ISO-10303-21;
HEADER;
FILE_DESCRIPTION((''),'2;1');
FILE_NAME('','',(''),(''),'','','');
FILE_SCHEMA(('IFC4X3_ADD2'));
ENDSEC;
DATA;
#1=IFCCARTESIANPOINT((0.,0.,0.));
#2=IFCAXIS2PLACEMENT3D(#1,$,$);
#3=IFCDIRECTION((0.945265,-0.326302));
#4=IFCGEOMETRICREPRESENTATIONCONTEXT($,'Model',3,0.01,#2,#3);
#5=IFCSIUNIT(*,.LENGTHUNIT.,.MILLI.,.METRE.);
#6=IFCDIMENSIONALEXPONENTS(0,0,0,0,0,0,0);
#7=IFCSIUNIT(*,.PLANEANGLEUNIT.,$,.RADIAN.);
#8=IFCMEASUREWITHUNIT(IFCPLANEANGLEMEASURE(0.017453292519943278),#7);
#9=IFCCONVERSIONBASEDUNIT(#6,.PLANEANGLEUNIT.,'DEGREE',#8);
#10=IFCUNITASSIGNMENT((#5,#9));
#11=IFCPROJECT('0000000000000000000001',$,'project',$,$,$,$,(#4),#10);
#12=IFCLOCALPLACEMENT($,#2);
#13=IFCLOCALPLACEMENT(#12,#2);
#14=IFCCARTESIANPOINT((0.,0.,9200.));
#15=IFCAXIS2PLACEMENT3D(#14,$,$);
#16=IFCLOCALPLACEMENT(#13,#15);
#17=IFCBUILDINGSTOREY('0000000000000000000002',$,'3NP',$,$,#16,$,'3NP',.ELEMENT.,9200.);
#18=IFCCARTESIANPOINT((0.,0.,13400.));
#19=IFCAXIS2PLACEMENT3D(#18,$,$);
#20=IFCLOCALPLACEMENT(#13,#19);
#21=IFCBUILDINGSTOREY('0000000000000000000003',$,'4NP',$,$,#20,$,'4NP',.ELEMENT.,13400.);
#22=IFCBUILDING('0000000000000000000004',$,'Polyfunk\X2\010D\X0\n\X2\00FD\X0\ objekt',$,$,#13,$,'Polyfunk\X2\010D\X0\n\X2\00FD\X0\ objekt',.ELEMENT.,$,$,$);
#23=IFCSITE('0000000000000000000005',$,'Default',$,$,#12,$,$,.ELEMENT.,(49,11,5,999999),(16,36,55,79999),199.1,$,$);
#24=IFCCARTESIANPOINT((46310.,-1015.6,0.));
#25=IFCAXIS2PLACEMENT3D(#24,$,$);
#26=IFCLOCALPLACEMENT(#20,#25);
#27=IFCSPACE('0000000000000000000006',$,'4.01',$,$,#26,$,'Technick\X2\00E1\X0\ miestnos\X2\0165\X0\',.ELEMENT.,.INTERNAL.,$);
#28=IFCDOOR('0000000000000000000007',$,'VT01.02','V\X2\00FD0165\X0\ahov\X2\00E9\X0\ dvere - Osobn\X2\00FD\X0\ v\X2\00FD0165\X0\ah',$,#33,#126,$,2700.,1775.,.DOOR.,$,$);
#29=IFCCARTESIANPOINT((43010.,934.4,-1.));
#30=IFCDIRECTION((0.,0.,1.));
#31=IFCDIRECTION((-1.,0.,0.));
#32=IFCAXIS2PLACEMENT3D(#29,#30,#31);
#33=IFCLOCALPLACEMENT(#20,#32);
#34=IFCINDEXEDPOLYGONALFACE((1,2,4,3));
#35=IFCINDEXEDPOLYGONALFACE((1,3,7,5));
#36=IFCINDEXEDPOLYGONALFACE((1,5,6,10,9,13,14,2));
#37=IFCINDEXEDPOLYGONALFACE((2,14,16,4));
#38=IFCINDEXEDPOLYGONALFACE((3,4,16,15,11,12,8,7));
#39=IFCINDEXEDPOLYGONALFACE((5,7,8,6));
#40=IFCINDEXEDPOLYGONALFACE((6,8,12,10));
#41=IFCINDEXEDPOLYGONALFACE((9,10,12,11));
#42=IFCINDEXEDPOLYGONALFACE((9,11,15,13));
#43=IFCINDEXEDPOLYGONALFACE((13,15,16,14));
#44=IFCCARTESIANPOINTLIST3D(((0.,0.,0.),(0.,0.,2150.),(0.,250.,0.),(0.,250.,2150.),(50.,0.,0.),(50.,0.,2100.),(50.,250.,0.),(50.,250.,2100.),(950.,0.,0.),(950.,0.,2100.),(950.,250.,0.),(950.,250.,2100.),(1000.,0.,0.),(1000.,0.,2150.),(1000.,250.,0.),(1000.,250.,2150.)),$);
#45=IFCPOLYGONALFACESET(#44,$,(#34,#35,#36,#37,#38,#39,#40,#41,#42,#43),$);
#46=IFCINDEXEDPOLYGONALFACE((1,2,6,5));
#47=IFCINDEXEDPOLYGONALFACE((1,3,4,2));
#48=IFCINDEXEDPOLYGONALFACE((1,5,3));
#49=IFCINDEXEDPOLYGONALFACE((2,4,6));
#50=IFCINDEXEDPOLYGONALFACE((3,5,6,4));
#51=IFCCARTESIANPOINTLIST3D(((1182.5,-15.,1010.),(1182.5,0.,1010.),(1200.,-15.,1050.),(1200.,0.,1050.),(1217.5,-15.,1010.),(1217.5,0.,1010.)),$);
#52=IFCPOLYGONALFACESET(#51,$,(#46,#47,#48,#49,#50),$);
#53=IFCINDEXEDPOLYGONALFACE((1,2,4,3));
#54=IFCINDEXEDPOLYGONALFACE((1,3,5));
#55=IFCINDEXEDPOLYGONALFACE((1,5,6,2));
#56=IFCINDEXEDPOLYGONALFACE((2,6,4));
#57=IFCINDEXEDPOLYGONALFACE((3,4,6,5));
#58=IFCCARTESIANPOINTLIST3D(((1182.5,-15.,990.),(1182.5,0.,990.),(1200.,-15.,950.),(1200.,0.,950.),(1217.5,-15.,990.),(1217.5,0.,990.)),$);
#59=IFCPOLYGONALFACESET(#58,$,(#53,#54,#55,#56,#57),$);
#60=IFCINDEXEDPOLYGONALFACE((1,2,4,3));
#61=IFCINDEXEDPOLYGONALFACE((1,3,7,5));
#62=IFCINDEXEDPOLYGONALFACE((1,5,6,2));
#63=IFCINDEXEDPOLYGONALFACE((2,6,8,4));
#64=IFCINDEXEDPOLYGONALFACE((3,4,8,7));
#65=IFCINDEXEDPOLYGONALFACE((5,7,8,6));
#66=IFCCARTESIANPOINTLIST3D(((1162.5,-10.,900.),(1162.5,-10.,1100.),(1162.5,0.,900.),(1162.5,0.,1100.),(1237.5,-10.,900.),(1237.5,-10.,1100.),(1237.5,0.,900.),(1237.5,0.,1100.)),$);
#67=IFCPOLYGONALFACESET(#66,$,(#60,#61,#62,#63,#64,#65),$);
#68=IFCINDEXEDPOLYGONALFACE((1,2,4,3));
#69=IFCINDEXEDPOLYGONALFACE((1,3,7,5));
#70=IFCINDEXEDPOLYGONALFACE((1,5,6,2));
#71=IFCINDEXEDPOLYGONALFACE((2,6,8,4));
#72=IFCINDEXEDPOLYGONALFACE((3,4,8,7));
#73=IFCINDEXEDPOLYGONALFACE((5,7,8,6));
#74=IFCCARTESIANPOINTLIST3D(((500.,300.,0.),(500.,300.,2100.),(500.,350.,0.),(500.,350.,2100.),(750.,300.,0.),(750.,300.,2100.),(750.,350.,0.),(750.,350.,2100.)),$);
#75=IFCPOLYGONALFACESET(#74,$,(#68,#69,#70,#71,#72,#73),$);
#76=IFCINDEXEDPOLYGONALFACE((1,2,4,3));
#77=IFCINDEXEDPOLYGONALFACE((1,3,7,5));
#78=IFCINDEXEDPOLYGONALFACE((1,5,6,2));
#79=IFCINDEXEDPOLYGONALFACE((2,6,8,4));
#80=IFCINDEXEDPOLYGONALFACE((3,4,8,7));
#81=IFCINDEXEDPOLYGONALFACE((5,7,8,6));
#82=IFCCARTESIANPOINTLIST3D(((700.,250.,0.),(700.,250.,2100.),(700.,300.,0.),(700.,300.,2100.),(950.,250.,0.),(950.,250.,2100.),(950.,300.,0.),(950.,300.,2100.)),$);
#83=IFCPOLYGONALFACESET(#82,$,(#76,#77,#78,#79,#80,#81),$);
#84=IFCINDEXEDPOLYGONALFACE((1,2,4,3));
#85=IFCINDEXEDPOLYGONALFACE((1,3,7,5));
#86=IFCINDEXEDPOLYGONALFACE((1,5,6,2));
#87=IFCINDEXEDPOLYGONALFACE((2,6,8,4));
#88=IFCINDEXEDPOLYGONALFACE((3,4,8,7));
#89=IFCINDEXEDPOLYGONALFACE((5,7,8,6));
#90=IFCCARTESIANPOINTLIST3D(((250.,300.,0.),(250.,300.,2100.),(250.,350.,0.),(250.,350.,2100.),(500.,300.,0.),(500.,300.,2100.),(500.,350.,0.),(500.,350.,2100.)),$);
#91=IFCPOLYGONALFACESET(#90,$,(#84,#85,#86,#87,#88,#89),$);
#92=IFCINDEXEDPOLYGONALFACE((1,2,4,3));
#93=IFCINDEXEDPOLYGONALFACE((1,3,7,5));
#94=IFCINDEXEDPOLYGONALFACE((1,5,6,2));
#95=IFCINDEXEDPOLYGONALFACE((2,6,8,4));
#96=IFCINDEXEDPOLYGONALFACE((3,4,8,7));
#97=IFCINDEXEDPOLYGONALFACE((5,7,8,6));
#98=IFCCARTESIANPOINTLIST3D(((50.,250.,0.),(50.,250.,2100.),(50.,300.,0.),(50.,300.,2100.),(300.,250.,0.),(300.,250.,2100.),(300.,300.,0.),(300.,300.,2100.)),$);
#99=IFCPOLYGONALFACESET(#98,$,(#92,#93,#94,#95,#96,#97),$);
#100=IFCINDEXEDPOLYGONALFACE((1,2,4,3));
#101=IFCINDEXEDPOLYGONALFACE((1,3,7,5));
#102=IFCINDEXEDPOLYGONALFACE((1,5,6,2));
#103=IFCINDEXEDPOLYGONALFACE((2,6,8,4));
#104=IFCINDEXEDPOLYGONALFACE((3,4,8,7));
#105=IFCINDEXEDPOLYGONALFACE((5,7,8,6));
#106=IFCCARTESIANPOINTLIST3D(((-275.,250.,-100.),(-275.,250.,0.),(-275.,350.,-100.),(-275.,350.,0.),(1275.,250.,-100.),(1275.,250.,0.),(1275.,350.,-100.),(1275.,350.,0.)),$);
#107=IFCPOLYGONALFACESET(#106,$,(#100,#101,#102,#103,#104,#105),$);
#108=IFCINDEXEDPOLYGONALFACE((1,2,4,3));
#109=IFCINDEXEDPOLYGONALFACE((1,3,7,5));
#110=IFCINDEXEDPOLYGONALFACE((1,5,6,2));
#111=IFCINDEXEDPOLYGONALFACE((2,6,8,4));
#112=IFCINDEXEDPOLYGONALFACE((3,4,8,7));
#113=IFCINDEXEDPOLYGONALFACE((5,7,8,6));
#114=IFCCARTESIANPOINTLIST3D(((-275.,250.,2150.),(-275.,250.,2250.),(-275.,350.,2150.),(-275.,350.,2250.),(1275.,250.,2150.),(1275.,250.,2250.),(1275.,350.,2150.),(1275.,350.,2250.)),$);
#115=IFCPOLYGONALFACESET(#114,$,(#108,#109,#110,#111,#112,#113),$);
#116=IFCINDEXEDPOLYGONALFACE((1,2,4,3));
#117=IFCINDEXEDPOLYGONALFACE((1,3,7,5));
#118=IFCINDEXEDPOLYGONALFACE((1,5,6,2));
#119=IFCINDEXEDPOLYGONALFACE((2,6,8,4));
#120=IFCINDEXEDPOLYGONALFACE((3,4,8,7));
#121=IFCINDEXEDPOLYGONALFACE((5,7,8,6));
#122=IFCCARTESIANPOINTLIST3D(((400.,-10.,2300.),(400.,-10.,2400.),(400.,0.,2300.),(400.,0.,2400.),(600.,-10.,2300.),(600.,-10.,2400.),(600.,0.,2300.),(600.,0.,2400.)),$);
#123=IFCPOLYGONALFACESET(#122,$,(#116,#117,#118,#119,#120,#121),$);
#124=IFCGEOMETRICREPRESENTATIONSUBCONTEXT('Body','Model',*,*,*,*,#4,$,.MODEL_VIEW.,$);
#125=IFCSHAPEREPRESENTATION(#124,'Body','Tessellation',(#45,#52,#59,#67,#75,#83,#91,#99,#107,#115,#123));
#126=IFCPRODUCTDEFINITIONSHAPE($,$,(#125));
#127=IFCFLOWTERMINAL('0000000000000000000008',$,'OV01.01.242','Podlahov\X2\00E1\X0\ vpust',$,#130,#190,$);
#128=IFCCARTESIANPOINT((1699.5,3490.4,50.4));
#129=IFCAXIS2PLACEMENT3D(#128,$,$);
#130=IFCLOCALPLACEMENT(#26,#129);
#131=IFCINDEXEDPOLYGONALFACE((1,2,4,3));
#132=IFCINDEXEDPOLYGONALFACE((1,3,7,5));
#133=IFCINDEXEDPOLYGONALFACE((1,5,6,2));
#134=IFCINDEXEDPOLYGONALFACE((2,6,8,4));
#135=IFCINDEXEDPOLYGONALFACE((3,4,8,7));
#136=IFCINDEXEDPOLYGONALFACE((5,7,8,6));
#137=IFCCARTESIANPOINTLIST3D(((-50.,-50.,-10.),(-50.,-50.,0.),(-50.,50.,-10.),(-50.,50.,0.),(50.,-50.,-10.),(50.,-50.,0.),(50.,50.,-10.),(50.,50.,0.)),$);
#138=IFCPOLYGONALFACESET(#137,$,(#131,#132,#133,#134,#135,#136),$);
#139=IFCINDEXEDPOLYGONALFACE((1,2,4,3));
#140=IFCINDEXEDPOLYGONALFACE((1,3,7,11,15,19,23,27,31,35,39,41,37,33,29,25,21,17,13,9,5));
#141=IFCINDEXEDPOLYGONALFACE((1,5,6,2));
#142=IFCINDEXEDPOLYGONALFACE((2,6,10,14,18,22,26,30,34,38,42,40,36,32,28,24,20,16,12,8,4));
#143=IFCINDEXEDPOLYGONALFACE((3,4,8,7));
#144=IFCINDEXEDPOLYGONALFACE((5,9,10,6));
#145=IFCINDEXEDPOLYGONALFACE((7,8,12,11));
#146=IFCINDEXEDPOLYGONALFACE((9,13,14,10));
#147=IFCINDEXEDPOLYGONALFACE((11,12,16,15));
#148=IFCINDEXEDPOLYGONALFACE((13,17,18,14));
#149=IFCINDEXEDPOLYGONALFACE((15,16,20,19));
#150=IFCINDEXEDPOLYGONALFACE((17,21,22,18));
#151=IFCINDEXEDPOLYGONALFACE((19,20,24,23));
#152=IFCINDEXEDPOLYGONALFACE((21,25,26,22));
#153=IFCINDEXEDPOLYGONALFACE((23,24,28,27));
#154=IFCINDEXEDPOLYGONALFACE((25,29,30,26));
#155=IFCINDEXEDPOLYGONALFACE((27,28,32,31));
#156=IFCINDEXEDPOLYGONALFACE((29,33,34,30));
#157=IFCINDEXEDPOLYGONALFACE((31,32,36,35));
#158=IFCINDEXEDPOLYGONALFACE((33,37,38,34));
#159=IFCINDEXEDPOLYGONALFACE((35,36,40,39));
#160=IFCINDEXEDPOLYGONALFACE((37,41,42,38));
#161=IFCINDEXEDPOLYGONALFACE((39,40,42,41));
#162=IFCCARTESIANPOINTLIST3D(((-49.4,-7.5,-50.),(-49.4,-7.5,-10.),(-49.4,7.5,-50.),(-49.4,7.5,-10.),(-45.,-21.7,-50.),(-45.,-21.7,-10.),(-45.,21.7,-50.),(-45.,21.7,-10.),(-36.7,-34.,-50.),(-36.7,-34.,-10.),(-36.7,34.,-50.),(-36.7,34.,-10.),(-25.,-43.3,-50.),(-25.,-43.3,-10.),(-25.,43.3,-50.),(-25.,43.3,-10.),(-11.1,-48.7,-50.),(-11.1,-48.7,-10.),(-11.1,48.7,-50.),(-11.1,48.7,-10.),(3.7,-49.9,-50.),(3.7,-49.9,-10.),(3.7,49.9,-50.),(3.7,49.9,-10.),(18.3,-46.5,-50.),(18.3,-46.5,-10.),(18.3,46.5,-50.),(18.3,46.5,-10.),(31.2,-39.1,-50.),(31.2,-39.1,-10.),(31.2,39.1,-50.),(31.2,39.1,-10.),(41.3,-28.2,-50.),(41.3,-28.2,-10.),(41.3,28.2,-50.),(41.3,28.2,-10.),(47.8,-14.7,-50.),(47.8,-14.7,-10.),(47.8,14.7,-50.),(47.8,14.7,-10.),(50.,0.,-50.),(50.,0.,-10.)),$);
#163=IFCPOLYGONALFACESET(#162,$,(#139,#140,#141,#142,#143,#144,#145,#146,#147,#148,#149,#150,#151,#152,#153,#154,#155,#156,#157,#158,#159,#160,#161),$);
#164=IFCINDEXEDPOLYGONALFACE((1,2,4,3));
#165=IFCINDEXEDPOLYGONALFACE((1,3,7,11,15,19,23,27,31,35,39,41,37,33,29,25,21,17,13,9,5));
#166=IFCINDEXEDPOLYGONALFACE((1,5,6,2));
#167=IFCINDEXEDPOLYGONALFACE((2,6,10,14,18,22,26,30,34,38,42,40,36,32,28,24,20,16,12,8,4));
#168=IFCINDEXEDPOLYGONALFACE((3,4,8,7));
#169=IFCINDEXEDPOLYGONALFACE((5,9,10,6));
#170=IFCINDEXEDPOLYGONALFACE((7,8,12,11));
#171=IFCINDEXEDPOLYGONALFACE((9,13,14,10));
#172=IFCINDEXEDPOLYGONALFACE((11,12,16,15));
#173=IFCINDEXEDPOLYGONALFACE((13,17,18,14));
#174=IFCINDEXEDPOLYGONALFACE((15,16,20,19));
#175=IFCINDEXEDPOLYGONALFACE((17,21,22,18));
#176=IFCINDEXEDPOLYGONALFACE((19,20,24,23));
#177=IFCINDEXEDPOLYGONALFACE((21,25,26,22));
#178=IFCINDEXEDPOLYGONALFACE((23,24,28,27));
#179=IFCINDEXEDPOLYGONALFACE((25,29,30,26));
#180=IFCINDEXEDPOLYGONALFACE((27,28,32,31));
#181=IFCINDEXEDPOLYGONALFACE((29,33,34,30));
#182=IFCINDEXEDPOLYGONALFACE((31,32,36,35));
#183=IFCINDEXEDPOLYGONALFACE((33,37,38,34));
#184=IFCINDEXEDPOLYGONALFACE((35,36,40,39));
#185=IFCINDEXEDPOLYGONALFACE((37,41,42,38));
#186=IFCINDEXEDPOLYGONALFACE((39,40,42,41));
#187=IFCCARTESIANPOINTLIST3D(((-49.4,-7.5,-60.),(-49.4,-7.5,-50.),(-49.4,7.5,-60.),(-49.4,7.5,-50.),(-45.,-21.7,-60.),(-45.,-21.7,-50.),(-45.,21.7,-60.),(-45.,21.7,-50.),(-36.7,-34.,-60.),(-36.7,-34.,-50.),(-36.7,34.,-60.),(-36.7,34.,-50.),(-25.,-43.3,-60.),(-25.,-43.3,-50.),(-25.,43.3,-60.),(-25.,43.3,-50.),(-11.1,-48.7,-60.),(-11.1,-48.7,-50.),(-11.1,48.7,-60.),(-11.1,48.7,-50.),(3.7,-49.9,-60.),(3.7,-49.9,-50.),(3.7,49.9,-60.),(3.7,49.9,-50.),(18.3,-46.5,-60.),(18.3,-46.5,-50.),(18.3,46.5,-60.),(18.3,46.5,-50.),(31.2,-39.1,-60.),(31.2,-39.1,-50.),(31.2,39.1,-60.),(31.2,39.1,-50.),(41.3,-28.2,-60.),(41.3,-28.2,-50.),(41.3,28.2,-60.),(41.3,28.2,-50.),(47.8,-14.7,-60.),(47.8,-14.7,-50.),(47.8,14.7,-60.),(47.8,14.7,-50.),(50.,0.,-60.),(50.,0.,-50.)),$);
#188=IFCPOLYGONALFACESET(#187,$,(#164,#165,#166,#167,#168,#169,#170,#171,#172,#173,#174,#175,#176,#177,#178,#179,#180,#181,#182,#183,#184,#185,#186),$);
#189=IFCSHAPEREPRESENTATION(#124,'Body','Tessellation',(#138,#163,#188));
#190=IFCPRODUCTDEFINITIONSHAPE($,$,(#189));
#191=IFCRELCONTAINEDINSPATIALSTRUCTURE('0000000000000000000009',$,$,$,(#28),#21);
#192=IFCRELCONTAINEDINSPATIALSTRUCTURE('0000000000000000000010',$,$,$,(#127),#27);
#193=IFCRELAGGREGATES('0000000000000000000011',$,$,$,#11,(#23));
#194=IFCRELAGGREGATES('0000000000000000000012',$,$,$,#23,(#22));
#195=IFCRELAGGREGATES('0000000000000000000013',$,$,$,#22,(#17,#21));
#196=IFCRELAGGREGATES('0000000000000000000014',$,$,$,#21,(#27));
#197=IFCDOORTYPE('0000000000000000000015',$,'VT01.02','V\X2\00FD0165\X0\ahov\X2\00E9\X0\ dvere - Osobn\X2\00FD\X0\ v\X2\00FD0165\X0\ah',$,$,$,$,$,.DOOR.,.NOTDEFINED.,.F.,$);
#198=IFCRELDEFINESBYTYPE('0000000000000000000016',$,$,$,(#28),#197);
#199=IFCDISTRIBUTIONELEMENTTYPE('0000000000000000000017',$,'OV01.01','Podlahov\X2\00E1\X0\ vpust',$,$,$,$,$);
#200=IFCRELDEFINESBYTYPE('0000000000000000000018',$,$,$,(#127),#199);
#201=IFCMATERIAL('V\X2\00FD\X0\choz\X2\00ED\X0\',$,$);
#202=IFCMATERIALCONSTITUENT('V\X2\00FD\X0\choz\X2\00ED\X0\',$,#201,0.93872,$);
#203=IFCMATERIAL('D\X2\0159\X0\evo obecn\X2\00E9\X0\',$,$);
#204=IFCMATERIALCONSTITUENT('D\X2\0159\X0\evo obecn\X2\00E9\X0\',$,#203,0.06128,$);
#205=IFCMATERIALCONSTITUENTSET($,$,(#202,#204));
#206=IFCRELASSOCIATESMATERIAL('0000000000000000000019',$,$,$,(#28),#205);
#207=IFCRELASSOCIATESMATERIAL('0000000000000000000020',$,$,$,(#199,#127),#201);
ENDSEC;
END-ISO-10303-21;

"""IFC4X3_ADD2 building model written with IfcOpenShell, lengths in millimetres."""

from ifc_helpers import new_model, entity, si_unit, converted_unit, direction, frame, frame_2d, origin, origin_2d_with_axis, place, context, subcontext, project, spatial, polyline, rectangle, circle, outline, extrude, source, transform, mapped, material, constituent, constituent_set, type_object, type_shapes, element, save


model = new_model("IFC4X3_ADD2")

# Units and contexts
model_context = context("Model", 3, precision=0.01, world=origin(), true_north=direction((0.945265, -0.326302)))
body_context = subcontext(model_context, "Body", "Model", "MODEL_VIEW")
ifc_project = project(units=[si_unit("LENGTHUNIT", "METRE", prefix="MILLI"), converted_unit("PLANEANGLEUNIT", "DEGREE", entity("IfcPlaneAngleMeasure", 0.017453292519943278), si_unit("PLANEANGLEUNIT", "RADIAN"), dimensions=[0, 0, 0, 0, 0, 0, 0])], contexts=[model_context])

# Site, building, storey
site_placement = place(None, origin())
site = spatial("IfcSite", under=ifc_project, at=site_placement, Name="Default", CompositionType="ELEMENT", RefLatitude=(49, 11, 5, 999999), RefLongitude=(16, 36, 55, 79999), RefElevation=199.1)
building_placement = place(site_placement, origin())
building = spatial("IfcBuilding", under=site, at=building_placement, Name="Polyfunkčný objekt", LongName="Polyfunkčný objekt", CompositionType="ELEMENT")
storey_1_placement = place(building_placement, frame((0.0, 0.0, 9200.0)))
storey_1 = spatial("IfcBuildingStorey", under=building, at=storey_1_placement, Name="3NP", LongName="3NP", CompositionType="ELEMENT", Elevation=9200.0)

# Shared definitions
storey_2_placement = place(building_placement, frame((0.0, 0.0, 13400.0)))
storey_2 = spatial("IfcBuildingStorey", under=building, at=storey_2_placement, Name="4NP", LongName="4NP", CompositionType="ELEMENT", Elevation=13400.0)

# Shared definitions
ifc_material_1 = material(Name="Dřevo obecné")

# Door
ifc_material_2 = material(Name="Výchozí")
ifc_constituent_1 = constituent(ifc_material_2, Name="Výchozí", fraction=0.93872)
ifc_constituent_2 = constituent(ifc_material_1, Name="Dřevo obecné", fraction=0.06128)
ifc_constituent_set = constituent_set(constituents=[ifc_constituent_1, ifc_constituent_2])
door_type = type_object("IfcDoorType", Name="VT01.02", Description="Výťahové dvere - Osobný výťah", OperationType="NOTDEFINED", ParameterTakesPrecedence=False, PredefinedType="DOOR")
shared_shape_1 = source(origin(), body_context, "Body", "SweptSolid", [
    extrude(outline(polyline([(-1087.5, -500.0), (1062.5, -500.0), (1062.5, -450.0), (-1037.5, -450.0), (-1037.5, 450.0), (1062.5, 450.0), (1062.5, 500.0), (-1087.5, 500.0), (-1087.5, -500.0)])), frame((500.0, 0.0, 1062.5), z_axis=(0.0, 1.0, 0.0), x_axis=(0.0, 0.0, -1.0)), (0.0, 0.0, 1.0), 250.0),
    extrude(outline(polyline([(-24.4, -10.7), (19.2, -10.7), (5.2, 21.4), (-24.4, -10.7)])), frame((1200.0, -15.0, 1023.3), z_axis=(0.0, 1.0, 0.0), x_axis=(0.400819, 0.0, -0.916157)), (0.0, 0.0, 1.0), 15.0),
    extrude(outline(polyline([(-24.4, -10.7), (19.2, -10.7), (5.2, 21.4), (-24.4, -10.7)])), frame((1200.0, -15.0, 976.7), z_axis=(0.0, 1.0, 0.0), x_axis=(-0.400819, 0.0, 0.916157)), (0.0, 0.0, 1.0), 15.0),
    extrude(rectangle(XDim=10.0, YDim=75.0, at=frame_2d((0.0, 0.0), x_axis=(1.0, 0.0))), frame((1200.0, -5.0, 900.0), z_axis=(0.0, 0.0, 1.0), x_axis=(0.0, 1.0, 0.0)), (0.0, 0.0, 1.0), 200.0),
    extrude(rectangle(XDim=50.0, YDim=250.0, at=origin_2d_with_axis()), frame((625.0, 325.0, 0.0), z_axis=(0.0, 0.0, 1.0), x_axis=(0.0, -1.0, 0.0)), (0.0, 0.0, 1.0), 2100.0),
    extrude(rectangle(XDim=50.0, YDim=250.0, at=frame_2d((0.0, 0.0), x_axis=(1.0, 0.0))), frame((825.0, 275.0, 0.0), z_axis=(0.0, 0.0, 1.0), x_axis=(0.0, -1.0, 0.0)), (0.0, 0.0, 1.0), 2100.0),
    extrude(rectangle(XDim=250.0, YDim=50.0, at=frame_2d((0.0, 0.0), x_axis=(1.0, 0.0))), frame((375.0, 325.0, 0.0), z_axis=(0.0, 0.0, 1.0), x_axis=(-1.0, 0.0, 0.0)), (0.0, 0.0, 1.0), 2100.0),
    extrude(rectangle(XDim=250.0, YDim=50.0, at=frame_2d((0.0, 0.0), x_axis=(1.0, 0.0))), frame((175.0, 275.0, 0.0), z_axis=(0.0, 0.0, 1.0), x_axis=(-1.0, 0.0, 0.0)), (0.0, 0.0, 1.0), 2100.0),
    extrude(rectangle(XDim=1550.0, YDim=100.0, at=frame_2d((0.0, 0.0), x_axis=(1.0, 0.0))), frame((500.0, 300.0, -100.0), z_axis=(0.0, 0.0, 1.0), x_axis=(-1.0, 0.0, 0.0)), (0.0, 0.0, 1.0), 100.0),
    extrude(rectangle(XDim=1550.0, YDim=100.0, at=frame_2d((0.0, 0.0), x_axis=(1.0, 0.0))), frame((500.0, 300.0, 2150.0), z_axis=(0.0, 0.0, 1.0), x_axis=(-1.0, 0.0, 0.0)), (0.0, 0.0, 1.0), 100.0),
    extrude(rectangle(XDim=10.0, YDim=200.0, at=frame_2d((0.0, 0.0), x_axis=(1.0, 0.0))), frame((500.0, -5.0, 2300.0), z_axis=(0.0, 0.0, 1.0), x_axis=(0.0, 1.0, 0.0)), (0.0, 0.0, 1.0), 100.0),
])
type_shapes(door_type, [shared_shape_1])
door_placement = place(storey_2_placement, frame((43010.0, 934.4, -1.0), z_axis=(0.0, 0.0, 1.0), x_axis=(-1.0, 0.0, 0.0)))
element("IfcDoor", 1, at=door_placement, inside=storey_2, type_object=door_type, material=ifc_constituent_set, Name="VT01.02", Description="Výťahové dvere - Osobný výťah", OverallHeight=2700.0, OverallWidth=1775.0, PredefinedType="DOOR", context=body_context, shape_type="MappedRepresentation", body=[
    mapped(shared_shape_1, transform((0.0, 0.0, 0.0), scale=1.0)),
])

# Shared definitions
space_placement = place(storey_2_placement, frame((46310.0, -1015.6, 0.0)))
space = spatial("IfcSpace", under=storey_2, at=space_placement, Name="4.01", LongName="Technická miestnosť", CompositionType="ELEMENT", PredefinedType="INTERNAL")

# Flow terminal
distribution_element_type = type_object("IfcDistributionElementType", Name="OV01.01", Description="Podlahová vpust", material=ifc_material_2)
shared_shape_2 = source(origin(), body_context, "Body", "SweptSolid", [
    extrude(rectangle(XDim=100.0, YDim=100.0, at=frame_2d((0.0, 0.0), x_axis=(1.0, 0.0))), frame((0.0, 0.0, -10.0), z_axis=(0.0, 0.0, 1.0), x_axis=(-1.0, 0.0, 0.0)), (0.0, 0.0, 1.0), 10.0),
    extrude(circle(Radius=50.0, at=frame_2d((0.0, 0.0), x_axis=(1.0, 0.0))), frame((0.0, 0.0, -50.0)), (0.0, 0.0, 1.0), 40.0),
    extrude(circle(Radius=50.0, at=frame_2d((0.0, 0.0), x_axis=(1.0, 0.0))), frame((0.0, 0.0, -60.0)), (0.0, 0.0, 1.0), 10.0),
])
type_shapes(distribution_element_type, [shared_shape_2])
flow_terminal_placement = place(space_placement, frame((1699.5, 3490.4, 50.4)))
element("IfcFlowTerminal", 2, at=flow_terminal_placement, inside=space, type_object=distribution_element_type, material=ifc_material_2, Name="OV01.01.242", Description="Podlahová vpust", context=body_context, shape_type="MappedRepresentation", body=[
    mapped(shared_shape_2, transform((0.0, 0.0, 0.0), scale=1.0)),
])

save(model, "model.ifc")
